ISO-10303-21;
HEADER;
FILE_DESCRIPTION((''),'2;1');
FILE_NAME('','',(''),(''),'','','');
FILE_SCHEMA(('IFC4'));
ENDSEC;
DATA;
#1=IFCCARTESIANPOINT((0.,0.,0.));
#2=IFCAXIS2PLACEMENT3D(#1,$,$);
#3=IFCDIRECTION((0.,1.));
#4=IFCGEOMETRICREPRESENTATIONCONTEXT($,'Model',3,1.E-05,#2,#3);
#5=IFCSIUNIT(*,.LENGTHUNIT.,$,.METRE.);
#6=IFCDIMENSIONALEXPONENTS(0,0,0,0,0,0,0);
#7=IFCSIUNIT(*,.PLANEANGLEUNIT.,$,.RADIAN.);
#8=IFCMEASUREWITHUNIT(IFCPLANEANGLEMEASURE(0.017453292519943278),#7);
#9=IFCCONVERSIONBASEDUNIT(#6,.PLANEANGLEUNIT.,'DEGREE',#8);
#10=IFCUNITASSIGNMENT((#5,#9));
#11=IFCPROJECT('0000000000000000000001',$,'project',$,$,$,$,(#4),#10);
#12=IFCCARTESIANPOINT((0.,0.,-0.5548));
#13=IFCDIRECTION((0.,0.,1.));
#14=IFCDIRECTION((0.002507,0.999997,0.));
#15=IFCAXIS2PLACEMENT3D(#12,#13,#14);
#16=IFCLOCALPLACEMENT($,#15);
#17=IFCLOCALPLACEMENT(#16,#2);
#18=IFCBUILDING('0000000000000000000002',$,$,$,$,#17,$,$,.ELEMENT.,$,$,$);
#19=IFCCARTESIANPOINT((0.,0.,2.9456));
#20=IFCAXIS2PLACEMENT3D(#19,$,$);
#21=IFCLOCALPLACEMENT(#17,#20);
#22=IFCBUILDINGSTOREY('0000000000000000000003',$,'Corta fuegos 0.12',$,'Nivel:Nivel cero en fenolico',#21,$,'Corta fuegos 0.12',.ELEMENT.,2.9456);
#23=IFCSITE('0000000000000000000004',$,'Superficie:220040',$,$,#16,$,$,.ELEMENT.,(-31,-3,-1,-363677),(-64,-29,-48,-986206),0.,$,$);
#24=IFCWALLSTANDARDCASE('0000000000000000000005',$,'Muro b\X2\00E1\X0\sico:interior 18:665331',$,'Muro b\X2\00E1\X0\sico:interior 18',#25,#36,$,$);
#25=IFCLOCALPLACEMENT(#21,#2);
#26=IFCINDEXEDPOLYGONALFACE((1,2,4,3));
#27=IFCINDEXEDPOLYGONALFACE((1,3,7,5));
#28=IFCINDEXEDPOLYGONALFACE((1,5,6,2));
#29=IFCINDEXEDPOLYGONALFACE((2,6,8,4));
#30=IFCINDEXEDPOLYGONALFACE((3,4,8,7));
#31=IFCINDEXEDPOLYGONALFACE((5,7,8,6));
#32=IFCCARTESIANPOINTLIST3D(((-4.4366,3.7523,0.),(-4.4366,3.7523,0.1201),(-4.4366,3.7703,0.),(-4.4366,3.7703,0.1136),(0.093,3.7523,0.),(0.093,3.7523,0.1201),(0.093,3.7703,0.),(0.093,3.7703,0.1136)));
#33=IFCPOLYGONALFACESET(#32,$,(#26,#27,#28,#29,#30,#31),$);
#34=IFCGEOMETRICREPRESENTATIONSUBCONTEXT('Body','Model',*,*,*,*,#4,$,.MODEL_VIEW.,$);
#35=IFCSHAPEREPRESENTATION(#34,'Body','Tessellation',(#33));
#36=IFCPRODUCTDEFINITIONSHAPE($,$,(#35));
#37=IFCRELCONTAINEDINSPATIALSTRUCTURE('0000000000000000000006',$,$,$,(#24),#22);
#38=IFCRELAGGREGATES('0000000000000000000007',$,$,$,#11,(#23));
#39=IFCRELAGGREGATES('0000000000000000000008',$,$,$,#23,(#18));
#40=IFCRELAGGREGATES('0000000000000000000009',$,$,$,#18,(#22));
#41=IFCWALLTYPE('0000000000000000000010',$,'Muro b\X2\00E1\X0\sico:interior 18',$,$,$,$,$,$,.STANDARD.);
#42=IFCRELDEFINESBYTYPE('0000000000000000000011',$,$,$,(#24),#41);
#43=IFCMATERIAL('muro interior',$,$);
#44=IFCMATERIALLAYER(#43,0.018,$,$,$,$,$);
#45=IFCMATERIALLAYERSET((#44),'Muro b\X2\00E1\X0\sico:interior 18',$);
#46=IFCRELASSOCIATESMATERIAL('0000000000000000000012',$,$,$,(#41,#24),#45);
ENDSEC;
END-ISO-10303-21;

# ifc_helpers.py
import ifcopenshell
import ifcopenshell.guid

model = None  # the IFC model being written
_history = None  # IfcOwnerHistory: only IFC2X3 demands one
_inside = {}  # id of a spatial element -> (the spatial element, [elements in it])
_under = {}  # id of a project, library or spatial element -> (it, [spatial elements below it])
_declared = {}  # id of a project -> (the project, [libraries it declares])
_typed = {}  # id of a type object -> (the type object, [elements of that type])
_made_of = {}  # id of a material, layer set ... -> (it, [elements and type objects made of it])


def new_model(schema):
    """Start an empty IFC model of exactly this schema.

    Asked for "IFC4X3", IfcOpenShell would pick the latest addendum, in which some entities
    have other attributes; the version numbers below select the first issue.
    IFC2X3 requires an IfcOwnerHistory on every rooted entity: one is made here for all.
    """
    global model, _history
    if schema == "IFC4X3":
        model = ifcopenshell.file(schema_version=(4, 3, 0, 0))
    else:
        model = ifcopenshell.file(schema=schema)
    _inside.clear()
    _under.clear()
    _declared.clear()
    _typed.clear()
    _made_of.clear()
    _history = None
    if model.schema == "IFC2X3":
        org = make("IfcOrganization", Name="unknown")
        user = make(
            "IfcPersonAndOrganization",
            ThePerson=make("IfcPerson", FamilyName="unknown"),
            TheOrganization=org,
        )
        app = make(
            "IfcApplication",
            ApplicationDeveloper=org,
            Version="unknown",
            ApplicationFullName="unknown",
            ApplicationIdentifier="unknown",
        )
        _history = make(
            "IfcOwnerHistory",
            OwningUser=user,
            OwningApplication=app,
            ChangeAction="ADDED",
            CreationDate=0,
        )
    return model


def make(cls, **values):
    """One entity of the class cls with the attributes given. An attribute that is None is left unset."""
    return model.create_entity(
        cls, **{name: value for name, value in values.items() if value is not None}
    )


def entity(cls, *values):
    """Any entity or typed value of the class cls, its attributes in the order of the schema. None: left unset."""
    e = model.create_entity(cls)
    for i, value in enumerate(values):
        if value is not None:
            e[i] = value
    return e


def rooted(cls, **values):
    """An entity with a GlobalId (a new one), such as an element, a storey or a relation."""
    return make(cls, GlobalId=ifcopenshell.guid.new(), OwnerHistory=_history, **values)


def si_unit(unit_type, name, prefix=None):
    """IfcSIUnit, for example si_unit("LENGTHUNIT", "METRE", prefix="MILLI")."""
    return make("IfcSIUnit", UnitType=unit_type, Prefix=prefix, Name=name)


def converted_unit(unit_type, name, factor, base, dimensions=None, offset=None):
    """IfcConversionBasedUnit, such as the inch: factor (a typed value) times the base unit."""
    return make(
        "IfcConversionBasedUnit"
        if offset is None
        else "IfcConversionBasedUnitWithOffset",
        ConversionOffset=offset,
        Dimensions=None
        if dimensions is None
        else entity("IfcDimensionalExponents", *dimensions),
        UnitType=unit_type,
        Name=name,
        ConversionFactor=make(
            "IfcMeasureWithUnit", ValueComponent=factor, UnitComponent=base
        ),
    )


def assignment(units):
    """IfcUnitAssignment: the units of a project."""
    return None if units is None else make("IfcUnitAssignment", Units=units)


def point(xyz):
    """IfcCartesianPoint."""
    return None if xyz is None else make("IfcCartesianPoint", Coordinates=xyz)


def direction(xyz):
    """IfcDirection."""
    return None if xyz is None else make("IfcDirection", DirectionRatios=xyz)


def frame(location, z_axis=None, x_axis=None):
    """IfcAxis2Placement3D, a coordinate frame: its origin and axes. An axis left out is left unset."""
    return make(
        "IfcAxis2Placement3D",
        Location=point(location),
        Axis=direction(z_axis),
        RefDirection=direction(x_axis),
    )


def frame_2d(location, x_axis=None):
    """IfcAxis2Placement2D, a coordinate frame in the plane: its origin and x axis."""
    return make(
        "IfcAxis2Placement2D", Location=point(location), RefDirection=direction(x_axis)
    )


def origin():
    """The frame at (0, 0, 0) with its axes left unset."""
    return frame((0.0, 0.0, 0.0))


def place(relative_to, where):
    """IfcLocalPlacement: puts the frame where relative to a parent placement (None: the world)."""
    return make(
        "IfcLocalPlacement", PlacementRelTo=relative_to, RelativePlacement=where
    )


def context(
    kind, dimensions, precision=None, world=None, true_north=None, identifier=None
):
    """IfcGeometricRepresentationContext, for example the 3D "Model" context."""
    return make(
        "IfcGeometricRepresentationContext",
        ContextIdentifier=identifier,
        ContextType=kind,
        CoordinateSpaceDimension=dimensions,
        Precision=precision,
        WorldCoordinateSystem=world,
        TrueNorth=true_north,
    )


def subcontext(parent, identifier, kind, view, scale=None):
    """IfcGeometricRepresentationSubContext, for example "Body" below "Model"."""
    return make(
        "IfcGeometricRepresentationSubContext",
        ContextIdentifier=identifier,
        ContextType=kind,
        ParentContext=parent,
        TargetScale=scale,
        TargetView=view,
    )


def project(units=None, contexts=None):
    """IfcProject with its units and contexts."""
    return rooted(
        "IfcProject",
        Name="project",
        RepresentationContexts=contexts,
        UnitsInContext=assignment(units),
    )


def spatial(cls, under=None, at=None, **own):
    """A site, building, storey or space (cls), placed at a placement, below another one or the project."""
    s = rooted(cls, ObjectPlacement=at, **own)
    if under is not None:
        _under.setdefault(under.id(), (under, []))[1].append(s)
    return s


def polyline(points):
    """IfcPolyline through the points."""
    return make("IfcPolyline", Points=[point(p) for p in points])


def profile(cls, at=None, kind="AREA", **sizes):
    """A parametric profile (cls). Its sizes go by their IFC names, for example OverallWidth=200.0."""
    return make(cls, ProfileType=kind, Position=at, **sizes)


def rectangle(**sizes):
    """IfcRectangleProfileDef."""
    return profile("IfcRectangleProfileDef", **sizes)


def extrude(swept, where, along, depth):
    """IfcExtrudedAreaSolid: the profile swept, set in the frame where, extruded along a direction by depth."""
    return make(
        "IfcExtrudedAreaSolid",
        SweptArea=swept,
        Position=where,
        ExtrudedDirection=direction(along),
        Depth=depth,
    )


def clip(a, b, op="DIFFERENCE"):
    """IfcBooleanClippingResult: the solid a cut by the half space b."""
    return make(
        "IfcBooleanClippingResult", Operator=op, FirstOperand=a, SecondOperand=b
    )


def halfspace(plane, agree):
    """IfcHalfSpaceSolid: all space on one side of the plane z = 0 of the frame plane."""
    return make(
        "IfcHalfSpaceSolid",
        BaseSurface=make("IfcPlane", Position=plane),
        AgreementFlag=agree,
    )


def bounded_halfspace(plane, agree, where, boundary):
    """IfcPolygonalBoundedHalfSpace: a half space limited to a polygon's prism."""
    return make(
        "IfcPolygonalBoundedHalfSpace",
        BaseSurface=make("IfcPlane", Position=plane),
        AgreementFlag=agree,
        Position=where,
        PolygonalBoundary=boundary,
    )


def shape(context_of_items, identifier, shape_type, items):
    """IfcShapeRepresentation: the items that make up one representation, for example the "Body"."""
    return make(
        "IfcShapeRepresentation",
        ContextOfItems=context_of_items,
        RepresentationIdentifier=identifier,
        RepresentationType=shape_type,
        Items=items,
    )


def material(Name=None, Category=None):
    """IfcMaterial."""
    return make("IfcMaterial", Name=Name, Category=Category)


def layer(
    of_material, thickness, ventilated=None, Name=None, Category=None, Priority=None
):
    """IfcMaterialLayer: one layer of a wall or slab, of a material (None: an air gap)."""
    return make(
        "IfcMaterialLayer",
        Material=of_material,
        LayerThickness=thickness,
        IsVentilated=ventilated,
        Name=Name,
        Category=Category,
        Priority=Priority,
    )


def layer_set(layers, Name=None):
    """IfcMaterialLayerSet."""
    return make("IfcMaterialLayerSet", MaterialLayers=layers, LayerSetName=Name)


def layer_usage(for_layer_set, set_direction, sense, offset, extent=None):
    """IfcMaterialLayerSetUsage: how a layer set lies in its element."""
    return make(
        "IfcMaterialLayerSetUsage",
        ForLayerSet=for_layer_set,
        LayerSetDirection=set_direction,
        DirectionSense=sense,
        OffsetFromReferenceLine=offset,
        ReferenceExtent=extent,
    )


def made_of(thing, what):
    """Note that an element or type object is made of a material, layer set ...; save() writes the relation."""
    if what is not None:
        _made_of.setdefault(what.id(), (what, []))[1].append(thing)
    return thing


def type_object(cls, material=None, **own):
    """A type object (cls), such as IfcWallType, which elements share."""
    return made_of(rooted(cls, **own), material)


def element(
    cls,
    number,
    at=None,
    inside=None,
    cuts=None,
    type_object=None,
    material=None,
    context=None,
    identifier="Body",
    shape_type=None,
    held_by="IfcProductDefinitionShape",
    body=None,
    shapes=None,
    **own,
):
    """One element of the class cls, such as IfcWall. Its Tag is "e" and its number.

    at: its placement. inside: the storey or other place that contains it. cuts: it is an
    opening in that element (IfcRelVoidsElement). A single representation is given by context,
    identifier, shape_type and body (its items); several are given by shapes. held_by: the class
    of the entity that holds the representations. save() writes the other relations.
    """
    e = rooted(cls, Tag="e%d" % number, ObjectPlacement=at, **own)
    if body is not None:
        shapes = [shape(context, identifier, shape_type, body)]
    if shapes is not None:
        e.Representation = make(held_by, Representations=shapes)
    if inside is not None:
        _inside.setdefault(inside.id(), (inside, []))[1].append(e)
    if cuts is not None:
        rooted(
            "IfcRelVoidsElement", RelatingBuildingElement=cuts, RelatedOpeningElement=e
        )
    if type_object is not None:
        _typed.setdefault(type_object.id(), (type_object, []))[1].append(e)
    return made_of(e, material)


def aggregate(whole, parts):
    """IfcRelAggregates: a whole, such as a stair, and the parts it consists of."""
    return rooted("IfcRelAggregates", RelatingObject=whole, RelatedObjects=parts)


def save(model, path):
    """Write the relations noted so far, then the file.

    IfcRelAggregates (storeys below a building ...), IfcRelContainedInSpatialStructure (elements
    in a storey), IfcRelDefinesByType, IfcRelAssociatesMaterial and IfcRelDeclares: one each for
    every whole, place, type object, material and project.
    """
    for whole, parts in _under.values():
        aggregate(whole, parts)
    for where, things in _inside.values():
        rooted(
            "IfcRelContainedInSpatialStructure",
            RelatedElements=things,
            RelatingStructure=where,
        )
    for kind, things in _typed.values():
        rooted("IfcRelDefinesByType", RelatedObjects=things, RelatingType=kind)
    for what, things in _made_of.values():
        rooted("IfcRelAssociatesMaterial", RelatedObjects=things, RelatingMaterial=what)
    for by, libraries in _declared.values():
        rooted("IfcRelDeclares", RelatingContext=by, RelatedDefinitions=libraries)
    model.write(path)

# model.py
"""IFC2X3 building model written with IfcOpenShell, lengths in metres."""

from ifc_helpers import new_model, entity, si_unit, converted_unit, direction, frame, frame_2d, origin, place, context, subcontext, project, spatial, polyline, rectangle, extrude, clip, halfspace, bounded_halfspace, material, layer, layer_set, layer_usage, type_object, element, save


model = new_model("IFC2X3")

# Units and contexts
model_context = context("Model", 3, precision=1e-05, world=origin(), true_north=direction((0.0, 1.0)))
body_context = subcontext(model_context, "Body", "Model", "MODEL_VIEW")
ifc_project = project(units=[si_unit("LENGTHUNIT", "METRE"), converted_unit("PLANEANGLEUNIT", "DEGREE", entity("IfcPlaneAngleMeasure", 0.017453292519943278), si_unit("PLANEANGLEUNIT", "RADIAN"), dimensions=[0, 0, 0, 0, 0, 0, 0])], contexts=[model_context])

# Site, building, storey
site_placement = place(None, frame((0.0, 0.0, -0.5548), z_axis=(0.0, 0.0, 1.0), x_axis=(0.002507, 0.999997, 0.0)))
site = spatial("IfcSite", under=ifc_project, at=site_placement, Name="Superficie:220040", CompositionType="ELEMENT", RefLatitude=(-31, -3, -1, -363677), RefLongitude=(-64, -29, -48, -986206), RefElevation=0.0)
building_placement = place(site_placement, origin())
building = spatial("IfcBuilding", under=site, at=building_placement, CompositionType="ELEMENT")
storey_placement = place(building_placement, frame((0.0, 0.0, 2.9456)))
storey = spatial("IfcBuildingStorey", under=building, at=storey_placement, Name="Corta fuegos 0.12", ObjectType="Nivel:Nivel cero en fenolico", LongName="Corta fuegos 0.12", CompositionType="ELEMENT", Elevation=2.9456)

# Wall
ifc_material_1 = material(Name="muro interior")
ifc_layer = layer(ifc_material_1, 0.018)
ifc_layer_set = layer_set([ifc_layer], Name="Muro básico:interior 18")
ifc_layer_usage = layer_usage(ifc_layer_set, "AXIS2", "NEGATIVE", 0.009)
wall_type = type_object("IfcWallType", Name="Muro básico:interior 18", PredefinedType="STANDARD", material=ifc_layer_set)
wall_placement = place(storey_placement, frame((-4.4366, 3.7613, 0.0)))
element("IfcWallStandardCase", 1, at=wall_placement, inside=storey, type_object=wall_type, material=ifc_layer_usage, Name="Muro básico:interior 18:665331", ObjectType="Muro básico:interior 18", context=body_context, shape_type="Clipping", body=[
    clip(clip(extrude(rectangle(XDim=4.5296, YDim=0.018, at=frame_2d((2.2648, 0.0), x_axis=(-1.0, 0.0))), origin(), (0.0, 0.0, 1.0), 0.1201), bounded_halfspace(frame((0.0, -0.009, 0.1201), z_axis=(0.0, 0.340697, 0.940173), x_axis=(1.0, 0.0, 0.0)), False, frame((0.0, -0.009, 0.1201)), polyline([(0.0, 0.0), (0.018, 0.0), (4.5116, 0.0), (4.5296, 0.0), (4.5296, 0.018), (0.0, 0.018), (0.0, 0.0)]))), halfspace(frame((0.0, 0.0, -2.8948)), True)),
])

save(model, "model.ifc")
